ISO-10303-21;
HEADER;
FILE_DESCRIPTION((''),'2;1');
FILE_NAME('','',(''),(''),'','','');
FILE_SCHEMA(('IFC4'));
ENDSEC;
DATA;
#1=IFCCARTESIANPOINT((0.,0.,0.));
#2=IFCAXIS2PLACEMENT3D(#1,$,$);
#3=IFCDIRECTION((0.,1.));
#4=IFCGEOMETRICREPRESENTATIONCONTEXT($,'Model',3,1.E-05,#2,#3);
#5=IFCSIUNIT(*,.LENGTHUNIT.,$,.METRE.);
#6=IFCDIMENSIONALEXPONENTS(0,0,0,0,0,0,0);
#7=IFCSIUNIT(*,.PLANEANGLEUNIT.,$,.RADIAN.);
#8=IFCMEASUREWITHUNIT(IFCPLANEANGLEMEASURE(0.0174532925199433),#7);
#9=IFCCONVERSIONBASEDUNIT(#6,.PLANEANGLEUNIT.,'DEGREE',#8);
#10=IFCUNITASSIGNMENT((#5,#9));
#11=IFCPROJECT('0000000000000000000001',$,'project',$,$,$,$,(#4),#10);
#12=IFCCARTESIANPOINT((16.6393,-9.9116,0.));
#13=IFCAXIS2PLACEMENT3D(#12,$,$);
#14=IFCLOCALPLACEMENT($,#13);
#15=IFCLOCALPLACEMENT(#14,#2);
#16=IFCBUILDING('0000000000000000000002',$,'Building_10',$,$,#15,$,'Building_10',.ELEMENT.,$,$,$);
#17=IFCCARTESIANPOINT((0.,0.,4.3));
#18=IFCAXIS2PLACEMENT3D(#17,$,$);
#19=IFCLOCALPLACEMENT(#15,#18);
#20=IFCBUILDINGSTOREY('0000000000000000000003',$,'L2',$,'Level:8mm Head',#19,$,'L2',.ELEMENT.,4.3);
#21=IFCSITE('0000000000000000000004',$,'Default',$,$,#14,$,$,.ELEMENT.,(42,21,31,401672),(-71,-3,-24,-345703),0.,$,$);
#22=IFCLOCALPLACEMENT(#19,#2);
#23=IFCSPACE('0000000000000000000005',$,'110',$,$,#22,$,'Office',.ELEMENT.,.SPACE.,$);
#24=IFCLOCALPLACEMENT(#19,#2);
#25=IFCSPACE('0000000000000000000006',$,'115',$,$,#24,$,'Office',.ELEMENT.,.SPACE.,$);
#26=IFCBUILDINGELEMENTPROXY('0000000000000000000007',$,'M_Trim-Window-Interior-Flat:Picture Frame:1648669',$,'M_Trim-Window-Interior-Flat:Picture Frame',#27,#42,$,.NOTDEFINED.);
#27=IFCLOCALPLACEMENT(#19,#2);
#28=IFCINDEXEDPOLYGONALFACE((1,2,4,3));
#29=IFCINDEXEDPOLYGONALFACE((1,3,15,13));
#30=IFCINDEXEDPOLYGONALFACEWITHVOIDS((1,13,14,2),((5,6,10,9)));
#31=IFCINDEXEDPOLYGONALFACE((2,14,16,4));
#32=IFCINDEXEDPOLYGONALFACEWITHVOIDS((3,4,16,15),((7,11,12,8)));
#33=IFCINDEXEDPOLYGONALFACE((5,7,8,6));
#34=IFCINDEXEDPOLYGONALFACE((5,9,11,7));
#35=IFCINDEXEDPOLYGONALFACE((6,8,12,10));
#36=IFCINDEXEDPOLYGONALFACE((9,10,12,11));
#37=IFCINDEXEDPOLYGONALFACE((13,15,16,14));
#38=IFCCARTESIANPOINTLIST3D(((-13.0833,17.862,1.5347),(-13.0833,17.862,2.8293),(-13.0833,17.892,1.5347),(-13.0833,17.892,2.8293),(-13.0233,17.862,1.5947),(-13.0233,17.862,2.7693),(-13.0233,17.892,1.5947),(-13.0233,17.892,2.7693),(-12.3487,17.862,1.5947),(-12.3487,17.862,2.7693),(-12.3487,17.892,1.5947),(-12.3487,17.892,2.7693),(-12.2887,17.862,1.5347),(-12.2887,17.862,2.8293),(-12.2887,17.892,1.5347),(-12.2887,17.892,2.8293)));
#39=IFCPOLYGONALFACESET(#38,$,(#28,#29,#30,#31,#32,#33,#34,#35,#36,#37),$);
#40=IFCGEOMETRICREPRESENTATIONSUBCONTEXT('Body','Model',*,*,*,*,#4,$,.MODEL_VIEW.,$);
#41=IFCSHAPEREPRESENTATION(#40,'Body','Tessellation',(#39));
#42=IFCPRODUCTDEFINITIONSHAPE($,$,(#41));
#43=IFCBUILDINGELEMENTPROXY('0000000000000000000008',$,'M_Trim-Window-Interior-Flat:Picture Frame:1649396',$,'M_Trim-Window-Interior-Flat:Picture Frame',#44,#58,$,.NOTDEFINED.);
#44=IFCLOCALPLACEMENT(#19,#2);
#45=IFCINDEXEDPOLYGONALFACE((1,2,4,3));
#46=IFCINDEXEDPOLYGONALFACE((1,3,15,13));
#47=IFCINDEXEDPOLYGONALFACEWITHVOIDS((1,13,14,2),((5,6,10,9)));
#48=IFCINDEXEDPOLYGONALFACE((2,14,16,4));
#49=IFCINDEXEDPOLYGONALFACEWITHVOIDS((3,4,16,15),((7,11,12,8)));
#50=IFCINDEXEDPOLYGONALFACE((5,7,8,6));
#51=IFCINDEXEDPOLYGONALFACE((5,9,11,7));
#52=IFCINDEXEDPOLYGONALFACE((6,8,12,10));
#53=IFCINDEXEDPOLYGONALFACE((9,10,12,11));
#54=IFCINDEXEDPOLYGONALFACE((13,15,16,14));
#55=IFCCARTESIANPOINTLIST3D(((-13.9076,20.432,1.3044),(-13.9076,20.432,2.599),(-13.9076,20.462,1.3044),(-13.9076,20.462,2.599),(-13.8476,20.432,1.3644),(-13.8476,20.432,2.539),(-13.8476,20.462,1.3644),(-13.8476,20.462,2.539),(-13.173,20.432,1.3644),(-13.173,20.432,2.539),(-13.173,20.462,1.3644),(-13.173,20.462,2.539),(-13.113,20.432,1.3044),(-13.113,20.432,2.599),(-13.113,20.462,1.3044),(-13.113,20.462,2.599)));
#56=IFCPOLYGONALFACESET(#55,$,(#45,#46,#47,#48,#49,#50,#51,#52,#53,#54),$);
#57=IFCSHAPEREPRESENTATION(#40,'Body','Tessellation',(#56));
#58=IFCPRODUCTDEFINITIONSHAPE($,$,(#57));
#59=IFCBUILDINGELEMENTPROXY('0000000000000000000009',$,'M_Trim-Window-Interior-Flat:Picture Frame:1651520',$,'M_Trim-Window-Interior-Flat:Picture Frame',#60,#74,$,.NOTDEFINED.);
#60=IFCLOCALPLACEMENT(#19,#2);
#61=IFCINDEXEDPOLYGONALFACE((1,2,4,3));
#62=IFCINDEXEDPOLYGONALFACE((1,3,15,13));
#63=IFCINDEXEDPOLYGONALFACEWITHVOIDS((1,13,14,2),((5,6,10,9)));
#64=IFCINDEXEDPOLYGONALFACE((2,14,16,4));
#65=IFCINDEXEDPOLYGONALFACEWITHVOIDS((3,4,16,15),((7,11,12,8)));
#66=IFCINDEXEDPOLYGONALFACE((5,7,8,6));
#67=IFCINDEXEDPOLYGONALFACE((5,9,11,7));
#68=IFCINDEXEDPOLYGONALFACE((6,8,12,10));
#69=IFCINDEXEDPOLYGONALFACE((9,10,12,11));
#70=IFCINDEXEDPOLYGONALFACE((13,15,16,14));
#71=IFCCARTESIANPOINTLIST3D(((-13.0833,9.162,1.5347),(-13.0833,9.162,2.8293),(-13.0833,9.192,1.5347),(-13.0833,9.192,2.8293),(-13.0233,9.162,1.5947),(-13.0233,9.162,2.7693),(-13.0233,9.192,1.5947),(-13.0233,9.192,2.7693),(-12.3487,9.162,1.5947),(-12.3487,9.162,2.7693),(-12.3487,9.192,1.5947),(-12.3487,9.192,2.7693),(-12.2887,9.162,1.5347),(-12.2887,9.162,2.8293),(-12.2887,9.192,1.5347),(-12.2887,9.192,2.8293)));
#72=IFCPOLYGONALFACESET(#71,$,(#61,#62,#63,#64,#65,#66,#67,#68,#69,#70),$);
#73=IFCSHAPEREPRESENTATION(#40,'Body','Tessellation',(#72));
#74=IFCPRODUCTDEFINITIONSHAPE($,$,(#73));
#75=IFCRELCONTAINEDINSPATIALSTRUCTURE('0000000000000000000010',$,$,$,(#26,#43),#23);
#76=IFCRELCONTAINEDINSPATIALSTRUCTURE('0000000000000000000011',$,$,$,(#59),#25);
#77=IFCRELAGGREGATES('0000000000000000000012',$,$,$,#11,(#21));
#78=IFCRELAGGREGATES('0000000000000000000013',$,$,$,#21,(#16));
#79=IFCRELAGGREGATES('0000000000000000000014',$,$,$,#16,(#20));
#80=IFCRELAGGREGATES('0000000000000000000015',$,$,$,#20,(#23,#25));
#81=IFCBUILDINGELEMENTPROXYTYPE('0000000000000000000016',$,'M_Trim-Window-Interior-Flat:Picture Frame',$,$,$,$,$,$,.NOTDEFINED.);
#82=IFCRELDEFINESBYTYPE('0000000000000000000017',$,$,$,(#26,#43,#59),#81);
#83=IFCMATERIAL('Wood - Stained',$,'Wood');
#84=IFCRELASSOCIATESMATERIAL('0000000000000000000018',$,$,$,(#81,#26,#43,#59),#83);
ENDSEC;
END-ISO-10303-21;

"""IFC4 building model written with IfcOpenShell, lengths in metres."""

from ifc_helpers import new_model, entity, si_unit, converted_unit, direction, frame, origin, place, context, subcontext, project, spatial, indexed_curve, outline, extrude, source, transform, mapped, material, type_object, type_shapes, element, save


model = new_model("IFC4")

# Units and contexts
model_context = context("Model", 3, precision=1e-05, world=origin(), true_north=direction((0.0, 1.0)))
body_context = subcontext(model_context, "Body", "Model", "MODEL_VIEW")
ifc_project = project(units=[si_unit("LENGTHUNIT", "METRE"), converted_unit("PLANEANGLEUNIT", "DEGREE", entity("IfcPlaneAngleMeasure", 0.0174532925199433), si_unit("PLANEANGLEUNIT", "RADIAN"), dimensions=[0, 0, 0, 0, 0, 0, 0])], contexts=[model_context])

# Site, building, storey
site_placement = place(None, frame((16.6393, -9.9116, 0.0)))
site = spatial("IfcSite", under=ifc_project, at=site_placement, Name="Default", CompositionType="ELEMENT", RefLatitude=(42, 21, 31, 401672), RefLongitude=(-71, -3, -24, -345703), RefElevation=0.0)
building_placement = place(site_placement, origin())
building = spatial("IfcBuilding", under=site, at=building_placement, Name="Building_10", LongName="Building_10", CompositionType="ELEMENT")
storey_placement = place(building_placement, frame((0.0, 0.0, 4.3)))
storey = spatial("IfcBuildingStorey", under=building, at=storey_placement, Name="L2", ObjectType="Level:8mm Head", LongName="L2", CompositionType="ELEMENT", Elevation=4.3)

# Shared definitions
ifc_material_1 = material(Name="Wood - Stained", Category="Wood")

# Shared definitions
space_1_placement = place(storey_placement, origin())
space_1 = spatial("IfcSpace", under=storey, at=space_1_placement, Name="110", LongName="Office", CompositionType="ELEMENT", PredefinedType="SPACE")

# Building element proxies
building_element_proxy_type_1 = type_object("IfcBuildingElementProxyType", Name="M_Trim-Window-Interior-Flat:Picture Frame", PredefinedType="NOTDEFINED", material=ifc_material_1)
shared_shape_1 = source(origin(), body_context, "Body", "SweptSolid", [
    extrude(outline(indexed_curve([(-0.3973, -0.6473), (0.3973, -0.6473), (0.3973, 0.6473), (-0.3973, 0.6473), (-0.3973, -0.6473)], self_intersect=False), holes=[indexed_curve([(-0.3373, -0.5873), (-0.3373, 0.5873), (0.3373, 0.5873), (0.3373, -0.5873), (-0.3373, -0.5873)], self_intersect=False)]), frame((0.0, -0.6, 0.0), z_axis=(0.0, 0.0, 1.0), x_axis=(-1.0, 0.0, 0.0)), (0.0, 0.0, 1.0), 0.03),
])
type_shapes(building_element_proxy_type_1, [shared_shape_1])
for number, where, z_axis, x_axis, name in (
    (1, (-12.686, 17.862, 2.782), (0.0, 1.0, 0.0), (-1.0, 0.0, 0.0), "M_Trim-Window-Interior-Flat:Picture Frame:1648669"),
    (2, (-13.5103, 20.462, 2.5517), (0.0, -1.0, 0.0), (1.0, 0.0, 0.0), "M_Trim-Window-Interior-Flat:Picture Frame:1649396"),
):
    element("IfcBuildingElementProxy", number, at=place(space_1_placement, frame(where, z_axis=z_axis, x_axis=x_axis)), inside=space_1, type_object=building_element_proxy_type_1, material=ifc_material_1, Name=name, ObjectType="M_Trim-Window-Interior-Flat:Picture Frame", PredefinedType="NOTDEFINED", context=body_context, shape_type="MappedRepresentation", body=[
        mapped(shared_shape_1, transform((0.0, 0.0, 0.0), scale=1.0)),
    ])

# Shared definitions
space_2_placement = place(storey_placement, origin())
space_2 = spatial("IfcSpace", under=storey, at=space_2_placement, Name="115", LongName="Office", CompositionType="ELEMENT", PredefinedType="SPACE")

# Building element proxy
proxy_1_placement = place(space_2_placement, frame((-12.686, 9.162, 2.782), z_axis=(0.0, 1.0, 0.0), x_axis=(-1.0, 0.0, 0.0)))
element("IfcBuildingElementProxy", 3, at=proxy_1_placement, inside=space_2, type_object=building_element_proxy_type_1, material=ifc_material_1, Name="M_Trim-Window-Interior-Flat:Picture Frame:1651520", ObjectType="M_Trim-Window-Interior-Flat:Picture Frame", PredefinedType="NOTDEFINED", context=body_context, shape_type="MappedRepresentation", body=[
    mapped(shared_shape_1, transform((0.0, 0.0, 0.0), scale=1.0)),
])

save(model, "model.ifc")
